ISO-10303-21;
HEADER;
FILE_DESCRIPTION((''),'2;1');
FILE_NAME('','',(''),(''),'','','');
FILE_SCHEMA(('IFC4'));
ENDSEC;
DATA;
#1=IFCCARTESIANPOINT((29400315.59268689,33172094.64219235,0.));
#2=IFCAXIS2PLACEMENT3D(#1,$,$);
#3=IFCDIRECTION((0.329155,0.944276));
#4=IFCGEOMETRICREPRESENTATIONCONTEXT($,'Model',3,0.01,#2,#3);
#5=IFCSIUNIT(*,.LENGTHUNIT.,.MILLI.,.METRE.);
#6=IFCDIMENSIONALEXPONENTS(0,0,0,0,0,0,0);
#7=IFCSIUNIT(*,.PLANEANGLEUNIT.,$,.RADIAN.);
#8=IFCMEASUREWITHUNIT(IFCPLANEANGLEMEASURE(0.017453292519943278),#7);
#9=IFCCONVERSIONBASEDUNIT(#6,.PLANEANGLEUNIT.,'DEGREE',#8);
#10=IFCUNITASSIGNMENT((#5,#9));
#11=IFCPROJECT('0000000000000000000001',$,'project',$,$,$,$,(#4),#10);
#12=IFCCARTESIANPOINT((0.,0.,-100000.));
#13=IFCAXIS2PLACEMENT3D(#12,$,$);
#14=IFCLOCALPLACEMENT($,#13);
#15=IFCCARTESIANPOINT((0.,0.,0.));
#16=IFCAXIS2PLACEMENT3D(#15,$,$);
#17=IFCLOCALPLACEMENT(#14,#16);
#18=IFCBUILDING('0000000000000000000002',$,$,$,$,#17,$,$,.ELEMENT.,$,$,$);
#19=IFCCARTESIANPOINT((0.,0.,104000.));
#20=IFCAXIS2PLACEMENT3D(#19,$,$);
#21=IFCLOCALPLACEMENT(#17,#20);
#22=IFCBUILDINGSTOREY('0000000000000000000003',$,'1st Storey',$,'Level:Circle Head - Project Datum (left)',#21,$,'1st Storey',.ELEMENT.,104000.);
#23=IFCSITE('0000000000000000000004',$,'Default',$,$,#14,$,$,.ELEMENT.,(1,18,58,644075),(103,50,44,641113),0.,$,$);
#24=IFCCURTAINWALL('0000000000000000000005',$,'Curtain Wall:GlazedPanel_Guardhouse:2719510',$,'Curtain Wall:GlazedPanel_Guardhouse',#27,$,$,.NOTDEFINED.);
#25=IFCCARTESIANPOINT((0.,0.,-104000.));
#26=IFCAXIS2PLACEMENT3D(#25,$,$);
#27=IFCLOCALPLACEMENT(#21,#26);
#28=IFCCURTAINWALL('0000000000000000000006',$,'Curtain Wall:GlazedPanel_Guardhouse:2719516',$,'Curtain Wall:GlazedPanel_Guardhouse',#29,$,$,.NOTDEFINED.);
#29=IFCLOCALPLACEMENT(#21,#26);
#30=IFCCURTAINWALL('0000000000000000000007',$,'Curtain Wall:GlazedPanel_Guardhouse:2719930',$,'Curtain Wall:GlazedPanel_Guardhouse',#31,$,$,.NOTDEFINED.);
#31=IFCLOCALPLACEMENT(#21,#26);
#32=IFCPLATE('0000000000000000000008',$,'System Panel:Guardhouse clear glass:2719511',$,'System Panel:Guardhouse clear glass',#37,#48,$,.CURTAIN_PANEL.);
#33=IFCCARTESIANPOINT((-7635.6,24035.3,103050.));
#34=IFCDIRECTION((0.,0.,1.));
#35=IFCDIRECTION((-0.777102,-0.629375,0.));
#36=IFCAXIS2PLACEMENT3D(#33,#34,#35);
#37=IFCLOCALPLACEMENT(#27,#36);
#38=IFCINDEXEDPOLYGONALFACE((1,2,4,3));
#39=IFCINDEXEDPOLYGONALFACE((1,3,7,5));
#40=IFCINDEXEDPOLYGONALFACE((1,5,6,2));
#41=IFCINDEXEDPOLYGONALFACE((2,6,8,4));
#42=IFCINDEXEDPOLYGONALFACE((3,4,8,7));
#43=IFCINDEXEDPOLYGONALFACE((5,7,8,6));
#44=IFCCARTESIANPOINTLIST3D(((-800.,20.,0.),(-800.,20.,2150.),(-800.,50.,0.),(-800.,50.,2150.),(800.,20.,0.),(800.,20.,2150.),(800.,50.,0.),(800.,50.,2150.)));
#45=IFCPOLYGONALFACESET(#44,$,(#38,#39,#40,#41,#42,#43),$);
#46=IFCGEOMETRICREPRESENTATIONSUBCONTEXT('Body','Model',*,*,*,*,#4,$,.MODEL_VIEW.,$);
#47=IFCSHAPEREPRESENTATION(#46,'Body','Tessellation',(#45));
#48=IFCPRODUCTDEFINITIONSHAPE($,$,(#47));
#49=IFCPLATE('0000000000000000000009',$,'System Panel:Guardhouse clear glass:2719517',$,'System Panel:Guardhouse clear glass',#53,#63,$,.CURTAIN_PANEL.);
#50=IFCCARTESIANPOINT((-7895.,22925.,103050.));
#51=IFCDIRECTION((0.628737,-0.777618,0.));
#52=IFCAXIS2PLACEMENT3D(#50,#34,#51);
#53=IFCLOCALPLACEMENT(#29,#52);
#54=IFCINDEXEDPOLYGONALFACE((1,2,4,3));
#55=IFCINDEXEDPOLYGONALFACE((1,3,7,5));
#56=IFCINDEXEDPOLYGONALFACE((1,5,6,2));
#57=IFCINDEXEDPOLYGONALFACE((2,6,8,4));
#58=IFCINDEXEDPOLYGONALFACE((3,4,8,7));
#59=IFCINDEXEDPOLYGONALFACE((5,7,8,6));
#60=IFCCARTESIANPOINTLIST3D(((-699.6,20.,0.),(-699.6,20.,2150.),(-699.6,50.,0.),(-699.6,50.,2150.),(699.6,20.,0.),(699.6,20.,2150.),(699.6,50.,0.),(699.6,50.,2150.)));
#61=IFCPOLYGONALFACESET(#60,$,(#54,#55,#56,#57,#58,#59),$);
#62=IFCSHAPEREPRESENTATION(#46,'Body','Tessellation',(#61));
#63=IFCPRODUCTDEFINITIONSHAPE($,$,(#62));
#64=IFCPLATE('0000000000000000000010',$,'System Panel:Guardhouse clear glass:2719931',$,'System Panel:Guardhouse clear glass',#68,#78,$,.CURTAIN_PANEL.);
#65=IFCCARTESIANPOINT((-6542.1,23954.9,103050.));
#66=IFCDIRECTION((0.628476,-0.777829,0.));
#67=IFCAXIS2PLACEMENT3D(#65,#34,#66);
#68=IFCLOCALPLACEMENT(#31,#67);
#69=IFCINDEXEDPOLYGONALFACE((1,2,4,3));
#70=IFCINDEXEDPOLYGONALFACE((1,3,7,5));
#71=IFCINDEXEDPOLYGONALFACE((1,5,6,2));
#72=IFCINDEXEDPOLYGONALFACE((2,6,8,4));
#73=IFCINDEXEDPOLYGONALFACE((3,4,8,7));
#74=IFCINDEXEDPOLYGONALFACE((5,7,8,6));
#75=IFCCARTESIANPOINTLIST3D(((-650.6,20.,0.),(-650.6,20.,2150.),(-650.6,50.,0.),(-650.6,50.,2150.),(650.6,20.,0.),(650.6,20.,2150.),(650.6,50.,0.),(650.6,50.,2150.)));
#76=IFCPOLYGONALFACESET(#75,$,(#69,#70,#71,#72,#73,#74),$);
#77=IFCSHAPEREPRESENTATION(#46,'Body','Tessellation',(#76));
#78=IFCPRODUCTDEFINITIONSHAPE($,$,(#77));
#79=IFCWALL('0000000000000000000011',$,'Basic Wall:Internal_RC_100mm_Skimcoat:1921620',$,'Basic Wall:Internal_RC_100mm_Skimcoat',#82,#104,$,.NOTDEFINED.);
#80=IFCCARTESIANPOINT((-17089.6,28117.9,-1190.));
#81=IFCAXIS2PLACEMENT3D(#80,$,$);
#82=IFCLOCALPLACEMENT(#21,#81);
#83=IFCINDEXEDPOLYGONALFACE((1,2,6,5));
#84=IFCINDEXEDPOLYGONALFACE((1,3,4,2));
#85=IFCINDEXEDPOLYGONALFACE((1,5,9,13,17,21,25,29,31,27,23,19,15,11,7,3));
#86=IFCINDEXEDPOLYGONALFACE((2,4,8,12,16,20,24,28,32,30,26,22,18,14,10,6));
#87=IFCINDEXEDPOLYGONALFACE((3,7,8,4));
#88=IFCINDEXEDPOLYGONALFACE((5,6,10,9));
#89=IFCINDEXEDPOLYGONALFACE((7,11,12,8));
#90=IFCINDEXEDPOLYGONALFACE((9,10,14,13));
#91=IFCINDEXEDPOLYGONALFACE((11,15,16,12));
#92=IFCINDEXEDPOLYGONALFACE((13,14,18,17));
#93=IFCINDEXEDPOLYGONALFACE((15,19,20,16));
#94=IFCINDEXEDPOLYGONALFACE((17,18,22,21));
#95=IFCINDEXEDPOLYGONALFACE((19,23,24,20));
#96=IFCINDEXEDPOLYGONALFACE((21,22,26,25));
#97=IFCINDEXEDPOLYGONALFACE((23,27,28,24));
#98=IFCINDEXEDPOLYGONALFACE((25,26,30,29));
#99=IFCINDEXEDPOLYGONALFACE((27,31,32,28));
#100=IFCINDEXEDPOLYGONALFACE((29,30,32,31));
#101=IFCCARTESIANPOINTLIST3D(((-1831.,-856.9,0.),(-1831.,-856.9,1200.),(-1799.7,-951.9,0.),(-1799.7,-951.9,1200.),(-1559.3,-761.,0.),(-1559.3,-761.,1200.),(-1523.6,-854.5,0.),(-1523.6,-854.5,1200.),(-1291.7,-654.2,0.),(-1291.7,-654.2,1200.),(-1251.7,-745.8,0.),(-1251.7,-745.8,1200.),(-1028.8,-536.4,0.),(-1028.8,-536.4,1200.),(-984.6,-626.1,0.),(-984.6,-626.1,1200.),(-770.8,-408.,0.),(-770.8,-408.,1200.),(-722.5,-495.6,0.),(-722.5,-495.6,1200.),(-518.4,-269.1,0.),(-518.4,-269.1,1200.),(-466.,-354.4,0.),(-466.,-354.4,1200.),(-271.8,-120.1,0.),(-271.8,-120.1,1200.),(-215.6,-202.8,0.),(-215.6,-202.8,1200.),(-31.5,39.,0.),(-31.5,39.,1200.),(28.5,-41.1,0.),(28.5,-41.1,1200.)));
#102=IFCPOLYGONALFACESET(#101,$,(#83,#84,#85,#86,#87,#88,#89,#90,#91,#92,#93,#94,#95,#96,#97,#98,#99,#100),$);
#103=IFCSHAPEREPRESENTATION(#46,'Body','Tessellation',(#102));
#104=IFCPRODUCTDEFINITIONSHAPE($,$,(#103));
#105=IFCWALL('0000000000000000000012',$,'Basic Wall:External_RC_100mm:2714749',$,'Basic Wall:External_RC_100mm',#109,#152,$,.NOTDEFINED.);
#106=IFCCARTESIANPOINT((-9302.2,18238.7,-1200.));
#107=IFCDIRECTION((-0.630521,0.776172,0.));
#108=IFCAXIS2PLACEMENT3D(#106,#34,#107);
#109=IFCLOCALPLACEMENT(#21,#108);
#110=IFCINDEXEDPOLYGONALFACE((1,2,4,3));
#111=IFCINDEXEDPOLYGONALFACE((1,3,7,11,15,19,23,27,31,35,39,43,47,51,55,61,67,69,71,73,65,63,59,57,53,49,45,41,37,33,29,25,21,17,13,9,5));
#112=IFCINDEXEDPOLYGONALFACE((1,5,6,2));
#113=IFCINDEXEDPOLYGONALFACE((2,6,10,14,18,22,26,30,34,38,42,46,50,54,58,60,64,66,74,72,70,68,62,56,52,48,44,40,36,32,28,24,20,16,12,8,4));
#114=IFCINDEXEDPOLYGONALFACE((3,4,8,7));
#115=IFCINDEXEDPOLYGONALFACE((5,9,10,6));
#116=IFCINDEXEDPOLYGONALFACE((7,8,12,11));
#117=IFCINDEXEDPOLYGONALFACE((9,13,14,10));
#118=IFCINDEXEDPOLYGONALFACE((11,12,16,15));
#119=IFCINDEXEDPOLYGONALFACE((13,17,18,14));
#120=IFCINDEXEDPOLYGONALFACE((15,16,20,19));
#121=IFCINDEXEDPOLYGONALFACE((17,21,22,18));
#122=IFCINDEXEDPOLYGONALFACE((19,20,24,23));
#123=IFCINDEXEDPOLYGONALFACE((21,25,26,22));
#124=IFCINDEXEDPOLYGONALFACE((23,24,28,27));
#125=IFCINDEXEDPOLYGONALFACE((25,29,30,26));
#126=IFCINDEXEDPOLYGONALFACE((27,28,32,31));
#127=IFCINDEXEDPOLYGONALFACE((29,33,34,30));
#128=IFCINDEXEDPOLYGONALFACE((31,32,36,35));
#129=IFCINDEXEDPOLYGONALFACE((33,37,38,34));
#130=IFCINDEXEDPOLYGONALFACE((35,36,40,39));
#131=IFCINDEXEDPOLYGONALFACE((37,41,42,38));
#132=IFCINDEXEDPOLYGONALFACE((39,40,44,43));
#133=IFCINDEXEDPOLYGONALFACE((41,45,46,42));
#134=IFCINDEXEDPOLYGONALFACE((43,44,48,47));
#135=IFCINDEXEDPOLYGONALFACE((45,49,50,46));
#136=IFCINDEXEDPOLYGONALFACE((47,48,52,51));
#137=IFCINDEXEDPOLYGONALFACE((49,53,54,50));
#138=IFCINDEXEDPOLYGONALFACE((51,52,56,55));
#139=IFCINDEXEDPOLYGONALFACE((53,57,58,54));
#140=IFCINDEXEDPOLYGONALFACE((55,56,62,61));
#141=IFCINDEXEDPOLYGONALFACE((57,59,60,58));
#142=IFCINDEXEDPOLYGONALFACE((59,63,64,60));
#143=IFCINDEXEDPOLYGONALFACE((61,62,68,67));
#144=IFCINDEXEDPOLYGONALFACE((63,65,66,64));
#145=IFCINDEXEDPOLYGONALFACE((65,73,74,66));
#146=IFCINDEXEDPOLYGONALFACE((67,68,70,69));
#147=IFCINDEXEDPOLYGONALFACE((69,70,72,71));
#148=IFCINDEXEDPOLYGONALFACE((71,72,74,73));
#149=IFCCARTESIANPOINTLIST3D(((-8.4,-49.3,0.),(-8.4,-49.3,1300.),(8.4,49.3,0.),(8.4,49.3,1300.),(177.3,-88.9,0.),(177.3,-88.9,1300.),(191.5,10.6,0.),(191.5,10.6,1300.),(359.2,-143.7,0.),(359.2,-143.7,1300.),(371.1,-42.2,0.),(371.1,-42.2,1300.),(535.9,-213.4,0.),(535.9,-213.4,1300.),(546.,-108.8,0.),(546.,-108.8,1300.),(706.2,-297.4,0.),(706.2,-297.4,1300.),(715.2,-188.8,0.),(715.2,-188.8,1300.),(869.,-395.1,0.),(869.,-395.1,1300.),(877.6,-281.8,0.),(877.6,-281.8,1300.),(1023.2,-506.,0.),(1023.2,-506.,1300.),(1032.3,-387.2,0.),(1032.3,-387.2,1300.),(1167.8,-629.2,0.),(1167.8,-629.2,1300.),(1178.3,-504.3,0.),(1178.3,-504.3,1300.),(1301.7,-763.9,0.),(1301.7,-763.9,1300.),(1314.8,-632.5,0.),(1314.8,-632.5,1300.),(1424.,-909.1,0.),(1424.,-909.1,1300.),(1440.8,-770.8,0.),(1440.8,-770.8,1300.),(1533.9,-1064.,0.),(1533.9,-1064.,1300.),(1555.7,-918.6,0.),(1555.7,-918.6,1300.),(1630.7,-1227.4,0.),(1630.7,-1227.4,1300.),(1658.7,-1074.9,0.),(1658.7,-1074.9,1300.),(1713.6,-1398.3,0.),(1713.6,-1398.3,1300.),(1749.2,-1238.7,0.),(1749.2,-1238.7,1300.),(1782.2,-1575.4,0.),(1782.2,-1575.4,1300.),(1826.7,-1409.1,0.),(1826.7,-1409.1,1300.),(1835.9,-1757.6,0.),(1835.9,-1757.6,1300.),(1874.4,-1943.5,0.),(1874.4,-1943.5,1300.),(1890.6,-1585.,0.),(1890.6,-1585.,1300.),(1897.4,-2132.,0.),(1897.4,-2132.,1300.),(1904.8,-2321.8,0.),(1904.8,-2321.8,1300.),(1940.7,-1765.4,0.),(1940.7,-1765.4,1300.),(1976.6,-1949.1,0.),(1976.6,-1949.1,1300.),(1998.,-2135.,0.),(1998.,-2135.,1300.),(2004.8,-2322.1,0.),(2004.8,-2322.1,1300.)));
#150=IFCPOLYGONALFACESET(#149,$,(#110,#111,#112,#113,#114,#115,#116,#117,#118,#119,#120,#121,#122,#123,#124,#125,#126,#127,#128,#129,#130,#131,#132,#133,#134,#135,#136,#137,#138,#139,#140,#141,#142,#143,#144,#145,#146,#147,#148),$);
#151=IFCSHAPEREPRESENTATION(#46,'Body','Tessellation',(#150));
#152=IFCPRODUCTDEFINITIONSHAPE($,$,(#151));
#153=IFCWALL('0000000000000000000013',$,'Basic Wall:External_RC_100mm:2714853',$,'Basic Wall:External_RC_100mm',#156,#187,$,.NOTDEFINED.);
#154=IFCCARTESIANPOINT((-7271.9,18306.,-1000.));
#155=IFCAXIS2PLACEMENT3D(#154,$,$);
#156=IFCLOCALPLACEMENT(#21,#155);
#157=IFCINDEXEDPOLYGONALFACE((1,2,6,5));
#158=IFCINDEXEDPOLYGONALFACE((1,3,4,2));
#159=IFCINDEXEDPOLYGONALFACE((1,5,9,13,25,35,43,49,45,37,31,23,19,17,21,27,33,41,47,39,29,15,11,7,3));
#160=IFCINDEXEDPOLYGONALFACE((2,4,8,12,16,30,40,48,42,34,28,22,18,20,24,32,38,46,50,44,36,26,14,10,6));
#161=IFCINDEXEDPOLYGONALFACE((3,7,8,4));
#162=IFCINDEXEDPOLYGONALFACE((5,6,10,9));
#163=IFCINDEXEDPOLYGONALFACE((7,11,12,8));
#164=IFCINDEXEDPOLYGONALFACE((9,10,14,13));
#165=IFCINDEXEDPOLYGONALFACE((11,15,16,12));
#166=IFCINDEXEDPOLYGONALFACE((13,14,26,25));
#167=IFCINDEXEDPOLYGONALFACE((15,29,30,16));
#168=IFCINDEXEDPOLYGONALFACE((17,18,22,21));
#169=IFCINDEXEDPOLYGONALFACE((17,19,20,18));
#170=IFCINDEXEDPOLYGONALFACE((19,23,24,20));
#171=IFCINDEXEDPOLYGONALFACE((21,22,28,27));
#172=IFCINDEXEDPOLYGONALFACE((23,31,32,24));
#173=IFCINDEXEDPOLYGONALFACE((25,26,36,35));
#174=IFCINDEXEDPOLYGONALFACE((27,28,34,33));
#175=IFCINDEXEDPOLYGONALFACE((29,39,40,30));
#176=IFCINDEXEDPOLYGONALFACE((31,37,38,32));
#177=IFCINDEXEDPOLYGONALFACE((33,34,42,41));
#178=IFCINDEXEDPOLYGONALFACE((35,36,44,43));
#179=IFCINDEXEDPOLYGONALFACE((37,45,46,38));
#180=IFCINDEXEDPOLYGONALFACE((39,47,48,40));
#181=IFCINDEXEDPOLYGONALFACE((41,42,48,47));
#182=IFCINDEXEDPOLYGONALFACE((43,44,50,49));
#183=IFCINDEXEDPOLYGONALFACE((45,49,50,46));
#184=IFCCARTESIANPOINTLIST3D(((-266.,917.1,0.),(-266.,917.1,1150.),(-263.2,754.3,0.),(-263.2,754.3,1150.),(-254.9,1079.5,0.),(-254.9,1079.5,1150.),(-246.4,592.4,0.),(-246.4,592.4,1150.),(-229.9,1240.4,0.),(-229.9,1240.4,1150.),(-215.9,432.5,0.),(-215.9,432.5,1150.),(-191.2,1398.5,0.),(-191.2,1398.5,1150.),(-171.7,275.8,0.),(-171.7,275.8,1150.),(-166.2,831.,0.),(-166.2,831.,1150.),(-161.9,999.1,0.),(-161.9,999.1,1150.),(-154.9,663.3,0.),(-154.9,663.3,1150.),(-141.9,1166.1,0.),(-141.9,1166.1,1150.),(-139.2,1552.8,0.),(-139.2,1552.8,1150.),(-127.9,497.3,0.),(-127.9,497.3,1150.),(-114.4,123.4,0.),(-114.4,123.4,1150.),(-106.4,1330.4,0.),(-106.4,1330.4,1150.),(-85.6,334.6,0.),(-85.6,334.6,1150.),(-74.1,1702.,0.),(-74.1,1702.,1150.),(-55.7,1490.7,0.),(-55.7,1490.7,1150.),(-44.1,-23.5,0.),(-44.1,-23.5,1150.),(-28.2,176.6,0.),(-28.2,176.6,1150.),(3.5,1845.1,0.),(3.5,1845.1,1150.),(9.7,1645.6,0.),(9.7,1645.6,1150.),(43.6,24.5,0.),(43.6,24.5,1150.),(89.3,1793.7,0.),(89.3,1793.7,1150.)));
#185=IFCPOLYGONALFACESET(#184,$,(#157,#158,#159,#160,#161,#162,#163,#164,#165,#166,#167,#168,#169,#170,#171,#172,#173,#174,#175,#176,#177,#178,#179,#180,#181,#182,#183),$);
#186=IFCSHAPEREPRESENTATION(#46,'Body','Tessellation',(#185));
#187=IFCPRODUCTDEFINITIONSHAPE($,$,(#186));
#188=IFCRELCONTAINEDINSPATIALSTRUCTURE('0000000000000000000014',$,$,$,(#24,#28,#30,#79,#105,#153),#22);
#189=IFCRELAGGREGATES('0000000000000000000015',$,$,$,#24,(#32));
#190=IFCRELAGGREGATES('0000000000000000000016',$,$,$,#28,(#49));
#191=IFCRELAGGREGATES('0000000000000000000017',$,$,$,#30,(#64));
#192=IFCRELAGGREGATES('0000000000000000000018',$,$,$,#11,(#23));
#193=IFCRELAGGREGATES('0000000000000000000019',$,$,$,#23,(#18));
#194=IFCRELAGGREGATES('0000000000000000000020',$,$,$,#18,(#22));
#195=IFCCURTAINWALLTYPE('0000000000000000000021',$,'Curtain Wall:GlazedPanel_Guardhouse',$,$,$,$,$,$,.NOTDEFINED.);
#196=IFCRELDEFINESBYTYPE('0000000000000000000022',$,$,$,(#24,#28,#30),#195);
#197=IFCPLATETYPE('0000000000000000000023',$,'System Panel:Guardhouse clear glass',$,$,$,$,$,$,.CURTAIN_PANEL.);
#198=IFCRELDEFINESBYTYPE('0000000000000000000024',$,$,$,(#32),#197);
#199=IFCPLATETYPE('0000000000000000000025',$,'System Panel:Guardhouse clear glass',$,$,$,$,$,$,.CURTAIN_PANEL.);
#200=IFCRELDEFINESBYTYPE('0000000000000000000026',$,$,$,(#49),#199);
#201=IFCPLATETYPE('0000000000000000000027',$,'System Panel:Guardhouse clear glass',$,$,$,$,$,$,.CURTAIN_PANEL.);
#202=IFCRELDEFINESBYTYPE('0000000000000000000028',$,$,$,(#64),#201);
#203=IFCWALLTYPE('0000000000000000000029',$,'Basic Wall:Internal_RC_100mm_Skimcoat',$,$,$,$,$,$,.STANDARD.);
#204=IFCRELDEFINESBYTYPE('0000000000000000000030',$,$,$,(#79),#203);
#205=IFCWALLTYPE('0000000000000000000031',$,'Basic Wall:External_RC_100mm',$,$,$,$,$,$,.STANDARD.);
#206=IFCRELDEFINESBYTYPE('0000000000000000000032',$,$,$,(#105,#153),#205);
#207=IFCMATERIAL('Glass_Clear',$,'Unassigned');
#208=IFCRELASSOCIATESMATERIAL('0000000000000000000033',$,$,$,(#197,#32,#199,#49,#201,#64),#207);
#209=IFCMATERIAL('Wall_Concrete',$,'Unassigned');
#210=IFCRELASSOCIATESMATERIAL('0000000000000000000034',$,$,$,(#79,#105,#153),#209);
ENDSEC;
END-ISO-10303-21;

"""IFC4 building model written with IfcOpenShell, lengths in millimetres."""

from ifc_helpers import new_model, entity, si_unit, converted_unit, direction, frame, origin, place, context, subcontext, project, spatial, line, arc, indexed_curve, outline, extrude, source, transform, mapped, material, type_object, type_shapes, element, aggregate, save


model = new_model("IFC4")

# Units and contexts
model_context = context("Model", 3, precision=0.01, world=frame((29400315.59268689, 33172094.64219235, 0.0)), true_north=direction((0.329155, 0.944276)))
body_context = subcontext(model_context, "Body", "Model", "MODEL_VIEW")
ifc_project = project(units=[si_unit("LENGTHUNIT", "METRE", prefix="MILLI"), converted_unit("PLANEANGLEUNIT", "DEGREE", entity("IfcPlaneAngleMeasure", 0.017453292519943278), si_unit("PLANEANGLEUNIT", "RADIAN"), dimensions=[0, 0, 0, 0, 0, 0, 0])], contexts=[model_context])

# Site, building, storey
site_placement = place(None, frame((0.0, 0.0, -100000.0)))
site = spatial("IfcSite", under=ifc_project, at=site_placement, Name="Default", CompositionType="ELEMENT", RefLatitude=(1, 18, 58, 644075), RefLongitude=(103, 50, 44, 641113), RefElevation=0.0)
building_placement = place(site_placement, origin())
building = spatial("IfcBuilding", under=site, at=building_placement, CompositionType="ELEMENT")
storey_placement = place(building_placement, frame((0.0, 0.0, 104000.0)))
storey = spatial("IfcBuildingStorey", under=building, at=storey_placement, Name="1st Storey", ObjectType="Level:Circle Head - Project Datum (left)", LongName="1st Storey", CompositionType="ELEMENT", Elevation=104000.0)

# Curtain wall
curtain_wall_type = type_object("IfcCurtainWallType", Name="Curtain Wall:GlazedPanel_Guardhouse", PredefinedType="NOTDEFINED")
curtain_wall_1_placement = place(storey_placement, frame((0.0, 0.0, -104000.0)))
curtain_wall_1 = element("IfcCurtainWall", 1, at=curtain_wall_1_placement, inside=storey, type_object=curtain_wall_type, Name="Curtain Wall:GlazedPanel_Guardhouse:2719510", ObjectType="Curtain Wall:GlazedPanel_Guardhouse", PredefinedType="NOTDEFINED")

# Curtain walls
curtain_wall_2_placement = place(storey_placement, frame((0.0, 0.0, -104000.0)))
curtain_wall_2 = element("IfcCurtainWall", 2, at=curtain_wall_2_placement, inside=storey, type_object=curtain_wall_type, Name="Curtain Wall:GlazedPanel_Guardhouse:2719516", ObjectType="Curtain Wall:GlazedPanel_Guardhouse", PredefinedType="NOTDEFINED")
curtain_wall_3_placement = place(storey_placement, frame((0.0, 0.0, -104000.0)))
curtain_wall_3 = element("IfcCurtainWall", 3, at=curtain_wall_3_placement, inside=storey, type_object=curtain_wall_type, Name="Curtain Wall:GlazedPanel_Guardhouse:2719930", ObjectType="Curtain Wall:GlazedPanel_Guardhouse", PredefinedType="NOTDEFINED")

# Plates
ifc_material_1 = material(Name="Glass_Clear", Category="Unassigned")
plate_type_1 = type_object("IfcPlateType", Name="System Panel:Guardhouse clear glass", PredefinedType="CURTAIN_PANEL", material=ifc_material_1)
shared_shape_1 = source(origin(), body_context, "Body", "SweptSolid", [
    extrude(outline(indexed_curve([(-15.0, -800.0), (15.0, -800.0), (15.0, 800.0), (-15.0, 800.0), (-15.0, -800.0)], self_intersect=False)), frame((0.0, 35.0, 0.0), z_axis=(0.0, 0.0, 1.0), x_axis=(0.0, 1.0, 0.0)), (0.0, 0.0, 1.0), 2150.0),
])
type_shapes(plate_type_1, [shared_shape_1])
plate_1_placement = place(curtain_wall_1_placement, frame((-7635.6, 24035.3, 103050.0), z_axis=(0.0, 0.0, 1.0), x_axis=(-0.777102, -0.629375, 0.0)))
plate_1 = element("IfcPlate", 4, at=plate_1_placement, type_object=plate_type_1, material=ifc_material_1, Name="System Panel:Guardhouse clear glass:2719511", ObjectType="System Panel:Guardhouse clear glass", PredefinedType="CURTAIN_PANEL", context=body_context, shape_type="MappedRepresentation", body=[
    mapped(shared_shape_1, transform((0.0, 0.0, 0.0), scale=1.0)),
])
aggregate(curtain_wall_1, [plate_1])
plate_type_2 = type_object("IfcPlateType", Name="System Panel:Guardhouse clear glass", PredefinedType="CURTAIN_PANEL", material=ifc_material_1)
shared_shape_2 = source(origin(), body_context, "Body", "SweptSolid", [
    extrude(outline(indexed_curve([(-15.0, -699.6), (15.0, -699.6), (15.0, 699.6), (-15.0, 699.6), (-15.0, -699.6)], self_intersect=False)), frame((0.0, 35.0, 0.0), z_axis=(0.0, 0.0, 1.0), x_axis=(0.0, 1.0, 0.0)), (0.0, 0.0, 1.0), 2150.0),
])
type_shapes(plate_type_2, [shared_shape_2])
plate_2_placement = place(curtain_wall_2_placement, frame((-7895.0, 22925.0, 103050.0), z_axis=(0.0, 0.0, 1.0), x_axis=(0.628737, -0.777618, 0.0)))
plate_2 = element("IfcPlate", 5, at=plate_2_placement, type_object=plate_type_2, material=ifc_material_1, Name="System Panel:Guardhouse clear glass:2719517", ObjectType="System Panel:Guardhouse clear glass", PredefinedType="CURTAIN_PANEL", context=body_context, shape_type="MappedRepresentation", body=[
    mapped(shared_shape_2, transform((0.0, 0.0, 0.0), scale=1.0)),
])
aggregate(curtain_wall_2, [plate_2])
plate_type_3 = type_object("IfcPlateType", Name="System Panel:Guardhouse clear glass", PredefinedType="CURTAIN_PANEL", material=ifc_material_1)
shared_shape_3 = source(origin(), body_context, "Body", "SweptSolid", [
    extrude(outline(indexed_curve([(-15.0, -650.6), (15.0, -650.6), (15.0, 650.6), (-15.0, 650.6), (-15.0, -650.6)], self_intersect=False)), frame((0.0, 35.0, 0.0), z_axis=(0.0, 0.0, 1.0), x_axis=(0.0, 1.0, 0.0)), (0.0, 0.0, 1.0), 2150.0),
])
type_shapes(plate_type_3, [shared_shape_3])
plate_3_placement = place(curtain_wall_3_placement, frame((-6542.1, 23954.9, 103050.0), z_axis=(0.0, 0.0, 1.0), x_axis=(0.628476, -0.777829, 0.0)))
plate_3 = element("IfcPlate", 6, at=plate_3_placement, type_object=plate_type_3, material=ifc_material_1, Name="System Panel:Guardhouse clear glass:2719931", ObjectType="System Panel:Guardhouse clear glass", PredefinedType="CURTAIN_PANEL", context=body_context, shape_type="MappedRepresentation", body=[
    mapped(shared_shape_3, transform((0.0, 0.0, 0.0), scale=1.0)),
])
aggregate(curtain_wall_3, [plate_3])

# Walls
ifc_material_2 = material(Name="Wall_Concrete", Category="Unassigned")
wall_type_1 = type_object("IfcWallType", Name="Basic Wall:Internal_RC_100mm_Skimcoat", PredefinedType="STANDARD")
wall_1_placement = place(storey_placement, frame((-17089.6, 28117.9, -1190.0)))
element("IfcWall", 7, at=wall_1_placement, inside=storey, type_object=wall_type_1, material=ifc_material_2, Name="Basic Wall:Internal_RC_100mm_Skimcoat:1921620", ObjectType="Basic Wall:Internal_RC_100mm_Skimcoat", PredefinedType="NOTDEFINED", context=body_context, shape_type="SweptSolid", body=[
    extrude(outline(indexed_curve([(-1799.7, -951.9), (-852.9, -562.2), (28.5, -41.1), (-31.5, 39.0), (-899.1, -473.5), (-1831.0, -856.9)], segments=[arc(1, 2, 3), line(3, 4), arc(4, 5, 6), line(6, 1)], self_intersect=False)), origin(), (0.0, 0.0, 1.0), 1200.0),
])
wall_type_2 = type_object("IfcWallType", Name="Basic Wall:External_RC_100mm", PredefinedType="STANDARD")
wall_2_placement = place(storey_placement, frame((-9302.2, 18238.7, -1200.0), z_axis=(0.0, 0.0, 1.0), x_axis=(-0.630521, 0.776172, 0.0)))
element("IfcWall", 8, at=wall_2_placement, inside=storey, type_object=wall_type_2, material=ifc_material_2, Name="Basic Wall:External_RC_100mm:2714749", ObjectType="Basic Wall:External_RC_100mm", PredefinedType="NOTDEFINED", context=body_context, shape_type="SweptSolid", body=[
    extrude(outline(indexed_curve([(2004.8, -2322.1), (1440.8, -770.8), (8.4, 49.3), (-8.4, -49.3), (1364.3, -835.2), (1904.8, -2321.8)], segments=[arc(1, 2, 3), line(3, 4), arc(4, 5, 6), line(6, 1)], self_intersect=False)), origin(), (0.0, 0.0, 1.0), 1300.0),
])
wall_3_placement = place(storey_placement, frame((-7271.9, 18306.0, -1000.0)))
element("IfcWall", 9, at=wall_3_placement, inside=storey, type_object=wall_type_2, material=ifc_material_2, Name="Basic Wall:External_RC_100mm:2714853", ObjectType="Basic Wall:External_RC_100mm", PredefinedType="NOTDEFINED", context=body_context, shape_type="SweptSolid", body=[
    extrude(outline(indexed_curve([(3.5, 1845.1), (-266.0, 917.1), (-44.1, -23.5), (43.6, 24.5), (-166.0, 915.1), (89.3, 1793.7)], segments=[arc(1, 2, 3), line(3, 4), arc(4, 5, 6), line(6, 1)], self_intersect=False)), origin(), (0.0, 0.0, 1.0), 1150.0),
])

save(model, "model.ifc")
